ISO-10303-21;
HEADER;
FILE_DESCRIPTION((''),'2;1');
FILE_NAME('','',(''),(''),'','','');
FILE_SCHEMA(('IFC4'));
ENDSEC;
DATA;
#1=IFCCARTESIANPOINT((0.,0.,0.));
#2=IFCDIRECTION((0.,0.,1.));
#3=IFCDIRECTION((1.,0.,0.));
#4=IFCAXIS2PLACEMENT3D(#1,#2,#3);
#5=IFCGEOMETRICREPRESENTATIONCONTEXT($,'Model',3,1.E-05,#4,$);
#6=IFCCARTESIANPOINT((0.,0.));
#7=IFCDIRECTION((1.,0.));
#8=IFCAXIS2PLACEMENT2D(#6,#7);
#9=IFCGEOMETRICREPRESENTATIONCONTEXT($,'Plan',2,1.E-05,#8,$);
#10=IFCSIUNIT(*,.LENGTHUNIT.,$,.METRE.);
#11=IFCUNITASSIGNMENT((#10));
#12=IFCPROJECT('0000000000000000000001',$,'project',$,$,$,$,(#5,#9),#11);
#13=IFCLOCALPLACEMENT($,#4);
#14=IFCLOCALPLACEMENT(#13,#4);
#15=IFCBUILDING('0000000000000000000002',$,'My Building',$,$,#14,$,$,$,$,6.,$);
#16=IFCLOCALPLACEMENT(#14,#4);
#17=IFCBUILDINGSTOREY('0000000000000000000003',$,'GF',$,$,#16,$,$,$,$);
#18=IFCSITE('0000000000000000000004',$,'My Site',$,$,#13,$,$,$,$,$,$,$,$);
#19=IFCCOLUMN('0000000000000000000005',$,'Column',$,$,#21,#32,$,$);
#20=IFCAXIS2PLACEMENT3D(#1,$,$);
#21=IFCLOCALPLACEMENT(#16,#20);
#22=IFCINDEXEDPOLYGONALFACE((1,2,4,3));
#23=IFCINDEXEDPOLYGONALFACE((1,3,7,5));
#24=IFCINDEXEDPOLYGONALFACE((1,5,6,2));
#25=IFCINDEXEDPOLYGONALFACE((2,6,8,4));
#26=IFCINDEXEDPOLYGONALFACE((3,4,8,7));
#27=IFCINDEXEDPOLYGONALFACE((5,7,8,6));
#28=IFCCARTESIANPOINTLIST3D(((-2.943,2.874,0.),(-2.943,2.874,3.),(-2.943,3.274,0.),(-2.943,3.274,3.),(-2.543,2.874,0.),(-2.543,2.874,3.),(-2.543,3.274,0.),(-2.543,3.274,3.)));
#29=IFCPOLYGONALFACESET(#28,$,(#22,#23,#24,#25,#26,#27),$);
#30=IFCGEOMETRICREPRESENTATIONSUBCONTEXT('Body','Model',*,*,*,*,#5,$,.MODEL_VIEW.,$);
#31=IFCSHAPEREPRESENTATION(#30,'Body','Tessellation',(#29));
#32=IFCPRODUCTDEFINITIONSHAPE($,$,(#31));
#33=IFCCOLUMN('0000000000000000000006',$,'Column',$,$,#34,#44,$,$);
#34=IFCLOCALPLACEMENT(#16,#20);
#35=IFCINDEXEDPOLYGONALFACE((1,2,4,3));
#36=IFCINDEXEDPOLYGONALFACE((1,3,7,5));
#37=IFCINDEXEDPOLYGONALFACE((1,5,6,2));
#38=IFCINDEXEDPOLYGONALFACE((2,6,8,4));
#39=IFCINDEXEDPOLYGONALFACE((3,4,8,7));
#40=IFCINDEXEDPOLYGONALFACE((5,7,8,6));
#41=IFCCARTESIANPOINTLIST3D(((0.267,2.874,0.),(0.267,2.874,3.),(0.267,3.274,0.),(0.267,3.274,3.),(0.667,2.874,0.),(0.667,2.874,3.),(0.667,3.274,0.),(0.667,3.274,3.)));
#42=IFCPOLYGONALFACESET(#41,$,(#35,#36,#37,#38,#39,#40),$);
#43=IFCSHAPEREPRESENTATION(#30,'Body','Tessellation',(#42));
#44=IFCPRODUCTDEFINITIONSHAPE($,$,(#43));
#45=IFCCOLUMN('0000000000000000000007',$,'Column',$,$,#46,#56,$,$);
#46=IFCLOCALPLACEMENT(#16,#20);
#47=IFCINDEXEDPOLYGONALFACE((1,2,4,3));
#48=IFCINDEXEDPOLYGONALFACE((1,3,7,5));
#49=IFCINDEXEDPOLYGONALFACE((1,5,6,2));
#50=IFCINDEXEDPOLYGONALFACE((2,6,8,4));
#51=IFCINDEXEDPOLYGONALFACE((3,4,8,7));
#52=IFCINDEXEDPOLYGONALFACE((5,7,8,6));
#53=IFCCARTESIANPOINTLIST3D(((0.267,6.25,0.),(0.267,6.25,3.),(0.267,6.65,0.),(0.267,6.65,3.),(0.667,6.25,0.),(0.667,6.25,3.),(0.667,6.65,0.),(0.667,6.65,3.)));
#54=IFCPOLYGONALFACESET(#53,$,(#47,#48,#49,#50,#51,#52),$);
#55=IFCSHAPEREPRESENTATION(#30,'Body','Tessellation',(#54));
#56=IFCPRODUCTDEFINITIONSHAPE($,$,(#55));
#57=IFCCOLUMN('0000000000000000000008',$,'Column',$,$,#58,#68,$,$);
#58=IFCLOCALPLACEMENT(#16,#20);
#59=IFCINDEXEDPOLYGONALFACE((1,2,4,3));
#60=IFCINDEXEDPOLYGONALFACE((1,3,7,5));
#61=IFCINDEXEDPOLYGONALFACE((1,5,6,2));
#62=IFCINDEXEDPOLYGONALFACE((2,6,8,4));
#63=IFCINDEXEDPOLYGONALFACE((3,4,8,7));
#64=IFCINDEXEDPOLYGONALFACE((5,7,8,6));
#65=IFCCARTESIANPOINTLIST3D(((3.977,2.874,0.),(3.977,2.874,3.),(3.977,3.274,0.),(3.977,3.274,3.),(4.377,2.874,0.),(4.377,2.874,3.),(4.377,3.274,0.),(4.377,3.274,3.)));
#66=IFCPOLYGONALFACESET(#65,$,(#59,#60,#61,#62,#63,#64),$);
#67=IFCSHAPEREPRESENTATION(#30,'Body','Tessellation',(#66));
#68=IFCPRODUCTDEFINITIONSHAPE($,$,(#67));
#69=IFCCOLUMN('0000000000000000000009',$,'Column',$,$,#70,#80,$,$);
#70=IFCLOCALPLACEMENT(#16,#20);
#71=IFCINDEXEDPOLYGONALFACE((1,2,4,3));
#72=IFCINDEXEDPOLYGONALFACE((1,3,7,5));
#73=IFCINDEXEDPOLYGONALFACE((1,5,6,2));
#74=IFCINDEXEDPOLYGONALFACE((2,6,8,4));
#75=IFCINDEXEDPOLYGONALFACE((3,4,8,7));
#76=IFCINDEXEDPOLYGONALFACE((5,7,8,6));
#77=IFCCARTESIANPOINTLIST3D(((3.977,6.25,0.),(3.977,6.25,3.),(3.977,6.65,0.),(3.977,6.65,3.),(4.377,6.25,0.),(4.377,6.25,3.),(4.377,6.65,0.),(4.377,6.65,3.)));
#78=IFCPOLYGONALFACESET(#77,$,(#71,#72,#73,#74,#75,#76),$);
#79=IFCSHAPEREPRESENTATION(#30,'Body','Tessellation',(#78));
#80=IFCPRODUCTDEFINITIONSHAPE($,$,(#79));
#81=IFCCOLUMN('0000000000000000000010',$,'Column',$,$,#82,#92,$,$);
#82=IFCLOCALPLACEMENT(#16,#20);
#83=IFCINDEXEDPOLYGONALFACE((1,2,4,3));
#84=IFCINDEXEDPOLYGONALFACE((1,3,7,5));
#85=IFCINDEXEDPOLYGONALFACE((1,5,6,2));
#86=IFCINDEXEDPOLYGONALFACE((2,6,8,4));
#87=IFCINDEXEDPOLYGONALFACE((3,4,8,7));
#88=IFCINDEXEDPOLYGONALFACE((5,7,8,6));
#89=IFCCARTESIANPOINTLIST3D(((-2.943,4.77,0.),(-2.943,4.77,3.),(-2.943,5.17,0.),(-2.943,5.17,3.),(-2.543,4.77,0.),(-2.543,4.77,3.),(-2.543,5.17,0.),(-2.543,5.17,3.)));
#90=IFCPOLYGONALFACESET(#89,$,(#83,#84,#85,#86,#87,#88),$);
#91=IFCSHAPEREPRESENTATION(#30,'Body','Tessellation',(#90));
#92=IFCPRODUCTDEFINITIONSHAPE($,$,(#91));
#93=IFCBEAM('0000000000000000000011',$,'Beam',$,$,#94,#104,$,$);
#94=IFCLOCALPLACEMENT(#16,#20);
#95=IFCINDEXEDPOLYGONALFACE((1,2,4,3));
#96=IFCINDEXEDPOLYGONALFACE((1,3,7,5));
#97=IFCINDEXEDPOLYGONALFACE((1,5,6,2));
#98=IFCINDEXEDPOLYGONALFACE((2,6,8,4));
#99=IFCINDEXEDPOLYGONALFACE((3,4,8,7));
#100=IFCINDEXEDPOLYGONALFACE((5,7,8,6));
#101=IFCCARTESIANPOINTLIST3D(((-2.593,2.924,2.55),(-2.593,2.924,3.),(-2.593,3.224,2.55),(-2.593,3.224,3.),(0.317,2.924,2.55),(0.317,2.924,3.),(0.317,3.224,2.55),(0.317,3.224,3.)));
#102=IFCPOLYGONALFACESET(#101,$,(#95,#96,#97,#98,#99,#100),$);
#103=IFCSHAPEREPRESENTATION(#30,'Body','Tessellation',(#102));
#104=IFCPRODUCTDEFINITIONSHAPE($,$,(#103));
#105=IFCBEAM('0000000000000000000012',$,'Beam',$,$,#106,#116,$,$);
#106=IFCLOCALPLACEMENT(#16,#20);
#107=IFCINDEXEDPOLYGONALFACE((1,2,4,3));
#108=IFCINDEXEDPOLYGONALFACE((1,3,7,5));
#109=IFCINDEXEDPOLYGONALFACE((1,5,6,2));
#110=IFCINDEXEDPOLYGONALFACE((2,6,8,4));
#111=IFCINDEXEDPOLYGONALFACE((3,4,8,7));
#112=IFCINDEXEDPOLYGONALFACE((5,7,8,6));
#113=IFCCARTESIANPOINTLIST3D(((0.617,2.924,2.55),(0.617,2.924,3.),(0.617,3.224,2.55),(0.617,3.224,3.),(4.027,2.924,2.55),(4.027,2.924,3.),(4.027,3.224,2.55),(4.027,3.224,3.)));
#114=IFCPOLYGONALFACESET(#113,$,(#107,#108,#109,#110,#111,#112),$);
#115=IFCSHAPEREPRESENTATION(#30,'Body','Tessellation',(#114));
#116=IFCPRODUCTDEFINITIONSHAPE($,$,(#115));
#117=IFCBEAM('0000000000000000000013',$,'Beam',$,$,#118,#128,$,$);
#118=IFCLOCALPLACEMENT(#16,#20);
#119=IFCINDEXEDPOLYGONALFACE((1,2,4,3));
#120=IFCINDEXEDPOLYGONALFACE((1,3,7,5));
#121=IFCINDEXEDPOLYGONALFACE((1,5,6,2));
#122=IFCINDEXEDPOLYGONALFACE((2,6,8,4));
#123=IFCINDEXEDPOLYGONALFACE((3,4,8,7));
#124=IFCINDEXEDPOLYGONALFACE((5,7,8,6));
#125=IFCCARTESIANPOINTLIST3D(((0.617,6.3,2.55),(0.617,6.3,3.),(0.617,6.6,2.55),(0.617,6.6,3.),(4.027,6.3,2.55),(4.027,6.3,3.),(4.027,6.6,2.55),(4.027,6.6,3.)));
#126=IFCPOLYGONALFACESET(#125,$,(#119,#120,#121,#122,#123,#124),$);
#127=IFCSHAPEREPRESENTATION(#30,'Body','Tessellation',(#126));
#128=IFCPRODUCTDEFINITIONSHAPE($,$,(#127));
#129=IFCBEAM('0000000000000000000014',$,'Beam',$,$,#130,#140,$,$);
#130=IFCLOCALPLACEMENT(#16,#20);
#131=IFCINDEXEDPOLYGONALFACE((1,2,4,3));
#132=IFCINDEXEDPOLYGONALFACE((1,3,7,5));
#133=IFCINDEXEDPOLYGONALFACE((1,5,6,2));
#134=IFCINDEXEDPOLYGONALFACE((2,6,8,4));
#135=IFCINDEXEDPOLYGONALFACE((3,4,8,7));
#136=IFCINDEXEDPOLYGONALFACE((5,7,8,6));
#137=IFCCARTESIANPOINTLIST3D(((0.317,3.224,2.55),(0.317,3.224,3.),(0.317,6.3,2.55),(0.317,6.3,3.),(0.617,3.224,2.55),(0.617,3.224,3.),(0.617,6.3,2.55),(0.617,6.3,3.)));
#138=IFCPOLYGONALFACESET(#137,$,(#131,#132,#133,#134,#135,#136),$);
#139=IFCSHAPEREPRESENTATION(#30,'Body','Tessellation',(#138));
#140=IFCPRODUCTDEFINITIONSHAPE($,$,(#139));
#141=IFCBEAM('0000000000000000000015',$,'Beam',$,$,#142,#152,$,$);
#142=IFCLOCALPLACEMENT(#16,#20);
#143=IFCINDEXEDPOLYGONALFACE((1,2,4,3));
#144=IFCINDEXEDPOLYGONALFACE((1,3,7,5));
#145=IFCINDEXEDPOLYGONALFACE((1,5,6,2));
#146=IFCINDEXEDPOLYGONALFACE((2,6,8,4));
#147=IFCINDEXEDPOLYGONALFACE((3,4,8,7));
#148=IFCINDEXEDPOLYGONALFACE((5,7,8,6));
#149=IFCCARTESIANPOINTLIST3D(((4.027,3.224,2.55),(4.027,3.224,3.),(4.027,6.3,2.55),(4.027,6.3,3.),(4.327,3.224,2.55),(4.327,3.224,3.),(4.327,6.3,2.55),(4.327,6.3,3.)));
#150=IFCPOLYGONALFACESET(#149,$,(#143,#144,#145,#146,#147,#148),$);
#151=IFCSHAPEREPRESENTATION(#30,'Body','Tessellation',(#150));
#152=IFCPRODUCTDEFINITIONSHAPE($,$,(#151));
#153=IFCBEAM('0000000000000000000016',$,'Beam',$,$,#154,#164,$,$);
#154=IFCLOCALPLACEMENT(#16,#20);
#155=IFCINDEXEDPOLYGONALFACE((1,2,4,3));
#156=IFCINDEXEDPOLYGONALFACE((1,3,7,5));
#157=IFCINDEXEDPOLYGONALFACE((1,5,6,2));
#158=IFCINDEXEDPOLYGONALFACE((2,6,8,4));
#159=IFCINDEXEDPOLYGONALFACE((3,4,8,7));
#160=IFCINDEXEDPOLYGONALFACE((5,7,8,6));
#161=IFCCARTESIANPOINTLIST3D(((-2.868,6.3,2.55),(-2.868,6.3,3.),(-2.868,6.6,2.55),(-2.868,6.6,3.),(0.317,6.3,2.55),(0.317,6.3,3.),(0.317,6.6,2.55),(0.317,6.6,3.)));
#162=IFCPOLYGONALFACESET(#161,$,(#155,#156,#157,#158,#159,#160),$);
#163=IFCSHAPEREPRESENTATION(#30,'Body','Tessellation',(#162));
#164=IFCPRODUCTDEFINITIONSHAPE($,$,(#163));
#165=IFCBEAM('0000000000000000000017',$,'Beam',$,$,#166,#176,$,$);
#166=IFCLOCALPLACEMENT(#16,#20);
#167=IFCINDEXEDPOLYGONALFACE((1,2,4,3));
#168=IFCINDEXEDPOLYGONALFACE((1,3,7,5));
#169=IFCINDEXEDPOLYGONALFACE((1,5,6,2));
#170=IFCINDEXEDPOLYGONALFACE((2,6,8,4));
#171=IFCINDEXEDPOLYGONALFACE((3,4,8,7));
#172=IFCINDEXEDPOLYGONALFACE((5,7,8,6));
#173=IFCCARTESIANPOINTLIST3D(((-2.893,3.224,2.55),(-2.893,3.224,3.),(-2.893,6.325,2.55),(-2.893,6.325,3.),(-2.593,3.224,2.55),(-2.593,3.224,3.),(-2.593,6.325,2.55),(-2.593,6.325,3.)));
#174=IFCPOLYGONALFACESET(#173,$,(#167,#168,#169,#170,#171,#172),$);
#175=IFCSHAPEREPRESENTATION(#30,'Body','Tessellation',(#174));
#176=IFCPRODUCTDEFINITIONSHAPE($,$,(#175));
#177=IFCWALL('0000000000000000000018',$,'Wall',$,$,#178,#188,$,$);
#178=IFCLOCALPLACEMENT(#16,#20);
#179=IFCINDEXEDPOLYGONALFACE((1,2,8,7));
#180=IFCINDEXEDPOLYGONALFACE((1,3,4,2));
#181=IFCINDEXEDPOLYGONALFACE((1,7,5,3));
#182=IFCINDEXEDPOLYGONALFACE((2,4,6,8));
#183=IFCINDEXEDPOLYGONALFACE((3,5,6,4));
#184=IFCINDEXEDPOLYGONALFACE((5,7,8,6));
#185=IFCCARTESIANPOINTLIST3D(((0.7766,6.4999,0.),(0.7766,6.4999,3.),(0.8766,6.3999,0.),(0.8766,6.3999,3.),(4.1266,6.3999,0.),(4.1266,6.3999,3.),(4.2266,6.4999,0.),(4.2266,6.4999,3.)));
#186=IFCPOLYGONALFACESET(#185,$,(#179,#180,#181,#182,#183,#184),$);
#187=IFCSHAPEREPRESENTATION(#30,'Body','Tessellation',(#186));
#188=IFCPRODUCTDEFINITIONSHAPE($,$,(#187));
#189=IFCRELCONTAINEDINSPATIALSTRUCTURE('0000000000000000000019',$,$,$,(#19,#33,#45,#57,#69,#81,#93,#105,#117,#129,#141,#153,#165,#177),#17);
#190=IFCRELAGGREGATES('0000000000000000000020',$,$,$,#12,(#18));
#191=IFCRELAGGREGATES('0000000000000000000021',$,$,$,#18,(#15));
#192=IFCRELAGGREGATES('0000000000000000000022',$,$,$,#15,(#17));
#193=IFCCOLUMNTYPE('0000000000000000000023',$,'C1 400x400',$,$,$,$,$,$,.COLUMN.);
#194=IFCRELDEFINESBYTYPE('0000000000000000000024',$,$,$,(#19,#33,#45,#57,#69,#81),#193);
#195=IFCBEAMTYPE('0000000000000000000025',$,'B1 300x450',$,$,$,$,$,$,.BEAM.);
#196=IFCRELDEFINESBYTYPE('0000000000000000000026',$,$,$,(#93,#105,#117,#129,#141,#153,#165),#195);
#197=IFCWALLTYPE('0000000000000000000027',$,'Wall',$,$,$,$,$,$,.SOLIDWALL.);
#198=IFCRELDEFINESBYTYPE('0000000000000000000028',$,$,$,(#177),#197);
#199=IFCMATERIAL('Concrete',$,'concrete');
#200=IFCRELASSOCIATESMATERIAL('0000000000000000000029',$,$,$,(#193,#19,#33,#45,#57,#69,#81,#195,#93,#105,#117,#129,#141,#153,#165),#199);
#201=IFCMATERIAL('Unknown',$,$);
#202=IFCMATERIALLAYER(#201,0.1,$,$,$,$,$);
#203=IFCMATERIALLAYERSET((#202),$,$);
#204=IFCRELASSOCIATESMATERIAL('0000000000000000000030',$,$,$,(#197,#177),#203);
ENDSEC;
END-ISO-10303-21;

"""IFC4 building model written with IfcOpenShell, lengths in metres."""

from ifc_helpers import new_model, si_unit, frame, origin_with_axes, origin_2d_with_axis, place, context, subcontext, project, spatial, line, indexed_curve, rectangle, outline, extrude, material, layer, layer_set, layer_usage, material_profile, profile_set, profile_usage, type_object, element, save


model = new_model("IFC4")

# Units and contexts
model_context = context("Model", 3, precision=1e-05, world=origin_with_axes())
plan_context = context("Plan", 2, precision=1e-05, world=origin_2d_with_axis())
body_context_1 = subcontext(model_context, "Body", "Model", "MODEL_VIEW")
ifc_project = project(units=[si_unit("LENGTHUNIT", "METRE")], contexts=[model_context, plan_context])

# Site, building, storey
site_placement = place(None, origin_with_axes())
site = spatial("IfcSite", under=ifc_project, at=site_placement, Name="My Site")
building_placement = place(site_placement, origin_with_axes())
building = spatial("IfcBuilding", under=site, at=building_placement, Name="My Building", ElevationOfTerrain=6.0)
storey_placement = place(building_placement, origin_with_axes())
storey = spatial("IfcBuildingStorey", under=building, at=storey_placement, Name="GF")

# Columns
ifc_material_1 = material(Name="Concrete", Category="concrete")
ifc_material_profile_1 = material_profile(ifc_material_1, rectangle(XDim=0.4, YDim=0.4))
ifc_profile_set_1 = profile_set([ifc_material_profile_1], Name="C1 400x400")
ifc_profile_usage_1 = profile_usage(ifc_profile_set_1, cardinal=5)
column_type = type_object("IfcColumnType", Name="C1 400x400", PredefinedType="COLUMN", material=ifc_profile_set_1)
column_1_placement = place(storey_placement, frame((-2.743, 3.074, 0.0), z_axis=(0.0, 0.0, 1.0), x_axis=(1.0, 0.0, 0.0)))
element("IfcColumn", 1, at=column_1_placement, inside=storey, type_object=column_type, material=ifc_profile_usage_1, Name="Column", context=body_context_1, shape_type="SweptSolid", body=[
    extrude(rectangle(XDim=0.4, YDim=0.4), origin_with_axes(), (0.0, 0.0, 1.0), 3.0),
])
ifc_profile_usage_2 = profile_usage(ifc_profile_set_1, cardinal=5)
column_2_placement = place(storey_placement, frame((0.467, 3.074, 0.0), z_axis=(0.0, 0.0, 1.0), x_axis=(1.0, 0.0, 0.0)))
element("IfcColumn", 2, at=column_2_placement, inside=storey, type_object=column_type, material=ifc_profile_usage_2, Name="Column", context=body_context_1, shape_type="SweptSolid", body=[
    extrude(rectangle(XDim=0.4, YDim=0.4), origin_with_axes(), (0.0, 0.0, 1.0), 3.0),
])
ifc_profile_usage_3 = profile_usage(ifc_profile_set_1, cardinal=5)
column_3_placement = place(storey_placement, frame((0.467, 6.45, 0.0), z_axis=(0.0, 0.0, 1.0), x_axis=(1.0, 0.0, 0.0)))
element("IfcColumn", 3, at=column_3_placement, inside=storey, type_object=column_type, material=ifc_profile_usage_3, Name="Column", context=body_context_1, shape_type="SweptSolid", body=[
    extrude(rectangle(XDim=0.4, YDim=0.4), origin_with_axes(), (0.0, 0.0, 1.0), 3.0),
])
ifc_profile_usage_4 = profile_usage(ifc_profile_set_1, cardinal=5)
column_4_placement = place(storey_placement, frame((4.177, 3.074, 0.0), z_axis=(0.0, 0.0, 1.0), x_axis=(1.0, 0.0, 0.0)))
element("IfcColumn", 4, at=column_4_placement, inside=storey, type_object=column_type, material=ifc_profile_usage_4, Name="Column", context=body_context_1, shape_type="SweptSolid", body=[
    extrude(rectangle(XDim=0.4, YDim=0.4), origin_with_axes(), (0.0, 0.0, 1.0), 3.0),
])
ifc_profile_usage_5 = profile_usage(ifc_profile_set_1, cardinal=5)
column_5_placement = place(storey_placement, frame((4.177, 6.45, 0.0), z_axis=(0.0, 0.0, 1.0), x_axis=(1.0, 0.0, 0.0)))
element("IfcColumn", 5, at=column_5_placement, inside=storey, type_object=column_type, material=ifc_profile_usage_5, Name="Column", context=body_context_1, shape_type="SweptSolid", body=[
    extrude(rectangle(XDim=0.4, YDim=0.4), origin_with_axes(), (0.0, 0.0, 1.0), 3.0),
])
ifc_profile_usage_6 = profile_usage(ifc_profile_set_1, cardinal=5)
column_6_placement = place(storey_placement, frame((-2.743, 4.97, 0.0), z_axis=(0.0, 0.0, 1.0), x_axis=(1.0, 0.0, 0.0)))
element("IfcColumn", 6, at=column_6_placement, inside=storey, type_object=column_type, material=ifc_profile_usage_6, Name="Column", context=body_context_1, shape_type="SweptSolid", body=[
    extrude(rectangle(XDim=0.4, YDim=0.4), origin_with_axes(), (0.0, 0.0, 1.0), 3.0),
])

# Beams
ifc_material_profile_2 = material_profile(ifc_material_1, rectangle(XDim=0.3, YDim=0.45))
ifc_profile_set_2 = profile_set([ifc_material_profile_2], Name="B1 300x450")
ifc_profile_usage_7 = profile_usage(ifc_profile_set_2, cardinal=8)
beam_type = type_object("IfcBeamType", Name="B1 300x450", PredefinedType="BEAM", material=ifc_profile_set_2)
beam_1_placement = place(storey_placement, frame((-2.593, 3.074, 2.975), z_axis=(1.0, 0.0, 0.0), x_axis=(0.0, 1.0, 0.0)))
element("IfcBeam", 7, at=beam_1_placement, inside=storey, type_object=beam_type, material=ifc_profile_usage_7, Name="Beam", context=body_context_1, shape_type="SweptSolid", body=[
    extrude(rectangle(XDim=0.3, YDim=0.45), frame((0.0, -0.2, 0.0), z_axis=(0.0, 0.0, 1.0), x_axis=(1.0, 0.0, 0.0)), (0.0, 0.0, 1.0), 2.91),
])
ifc_profile_usage_8 = profile_usage(ifc_profile_set_2, cardinal=8)
beam_2_placement = place(storey_placement, frame((0.617, 3.074, 2.975), z_axis=(1.0, 0.0, 0.0), x_axis=(0.0, 1.0, 0.0)))
element("IfcBeam", 8, at=beam_2_placement, inside=storey, type_object=beam_type, material=ifc_profile_usage_8, Name="Beam", context=body_context_1, shape_type="SweptSolid", body=[
    extrude(rectangle(XDim=0.3, YDim=0.45), frame((0.0, -0.2, 0.0), z_axis=(0.0, 0.0, 1.0), x_axis=(1.0, 0.0, 0.0)), (0.0, 0.0, 1.0), 3.41),
])
ifc_profile_usage_9 = profile_usage(ifc_profile_set_2, cardinal=8)
beam_3_placement = place(storey_placement, frame((0.617, 6.45, 2.975), z_axis=(1.0, 0.0, 0.0), x_axis=(0.0, 1.0, 0.0)))
element("IfcBeam", 9, at=beam_3_placement, inside=storey, type_object=beam_type, material=ifc_profile_usage_9, Name="Beam", context=body_context_1, shape_type="SweptSolid", body=[
    extrude(rectangle(XDim=0.3, YDim=0.45), frame((0.0, -0.2, 0.0), z_axis=(0.0, 0.0, 1.0), x_axis=(1.0, 0.0, 0.0)), (0.0, 0.0, 1.0), 3.41),
])
ifc_profile_usage_10 = profile_usage(ifc_profile_set_2, cardinal=8)
beam_4_placement = place(storey_placement, frame((0.467, 3.224, 2.975), z_axis=(0.0, 1.0, 0.0), x_axis=(-1.0, 0.0, 0.0)))
element("IfcBeam", 10, at=beam_4_placement, inside=storey, type_object=beam_type, material=ifc_profile_usage_10, Name="Beam", context=body_context_1, shape_type="SweptSolid", body=[
    extrude(rectangle(XDim=0.3, YDim=0.45), frame((0.0, -0.2, 0.0), z_axis=(0.0, 0.0, 1.0), x_axis=(1.0, 0.0, 0.0)), (0.0, 0.0, 1.0), 3.076),
])
ifc_profile_usage_11 = profile_usage(ifc_profile_set_2, cardinal=8)
beam_5_placement = place(storey_placement, frame((4.177, 3.224, 2.975), z_axis=(0.0, 1.0, 0.0), x_axis=(-1.0, 0.0, 0.0)))
element("IfcBeam", 11, at=beam_5_placement, inside=storey, type_object=beam_type, material=ifc_profile_usage_11, Name="Beam", context=body_context_1, shape_type="SweptSolid", body=[
    extrude(rectangle(XDim=0.3, YDim=0.45), frame((0.0, -0.2, 0.0), z_axis=(0.0, 0.0, 1.0), x_axis=(1.0, 0.0, 0.0)), (0.0, 0.0, 1.0), 3.076),
])
ifc_profile_usage_12 = profile_usage(ifc_profile_set_2, cardinal=8)
beam_6_placement = place(storey_placement, frame((-2.868, 6.45, 2.975), z_axis=(1.0, 0.0, 0.0), x_axis=(0.0, 1.0, 0.0)))
element("IfcBeam", 12, at=beam_6_placement, inside=storey, type_object=beam_type, material=ifc_profile_usage_12, Name="Beam", context=body_context_1, shape_type="SweptSolid", body=[
    extrude(rectangle(XDim=0.3, YDim=0.45), frame((0.0, -0.2, 0.0), z_axis=(0.0, 0.0, 1.0), x_axis=(1.0, 0.0, 0.0)), (0.0, 0.0, 1.0), 3.185),
])
ifc_profile_usage_13 = profile_usage(ifc_profile_set_2, cardinal=8)
beam_7_placement = place(storey_placement, frame((-2.743, 3.224, 2.975), z_axis=(0.0, 1.0, 0.0), x_axis=(-1.0, 0.0, 0.0)))
element("IfcBeam", 13, at=beam_7_placement, inside=storey, type_object=beam_type, material=ifc_profile_usage_13, Name="Beam", context=body_context_1, shape_type="SweptSolid", body=[
    extrude(rectangle(XDim=0.3, YDim=0.45), frame((0.0, -0.2, 0.0), z_axis=(0.0, 0.0, 1.0), x_axis=(1.0, 0.0, 0.0)), (0.0, 0.0, 1.0), 3.101),
])

# Wall
ifc_material_2 = material(Name="Unknown")
ifc_layer = layer(ifc_material_2, 0.1)
ifc_layer_set = layer_set([ifc_layer])
ifc_layer_usage_1 = layer_usage(ifc_layer_set, "AXIS2", "POSITIVE", 0.0)
wall_type = type_object("IfcWallType", Name="Wall", PredefinedType="SOLIDWALL", material=ifc_layer_set)
wall_1_placement = place(storey_placement, frame((4.2266, 6.4999, 0.0), z_axis=(0.0, 0.0, 1.0), x_axis=(-1.0, 0.0, 0.0)))
element("IfcWall", 14, at=wall_1_placement, inside=storey, type_object=wall_type, material=ifc_layer_usage_1, Name="Wall", context=body_context_1, shape_type="SweptSolid", body=[
    extrude(outline(indexed_curve([(0.0, 0.0), (0.1, 0.1), (3.35, 0.1), (3.45, 0.0)], segments=[line(1, 2, 3, 4, 1)])), origin_with_axes(), (0.0, 0.0, 1.0), 3.0),
])

save(model, "model.ifc")
